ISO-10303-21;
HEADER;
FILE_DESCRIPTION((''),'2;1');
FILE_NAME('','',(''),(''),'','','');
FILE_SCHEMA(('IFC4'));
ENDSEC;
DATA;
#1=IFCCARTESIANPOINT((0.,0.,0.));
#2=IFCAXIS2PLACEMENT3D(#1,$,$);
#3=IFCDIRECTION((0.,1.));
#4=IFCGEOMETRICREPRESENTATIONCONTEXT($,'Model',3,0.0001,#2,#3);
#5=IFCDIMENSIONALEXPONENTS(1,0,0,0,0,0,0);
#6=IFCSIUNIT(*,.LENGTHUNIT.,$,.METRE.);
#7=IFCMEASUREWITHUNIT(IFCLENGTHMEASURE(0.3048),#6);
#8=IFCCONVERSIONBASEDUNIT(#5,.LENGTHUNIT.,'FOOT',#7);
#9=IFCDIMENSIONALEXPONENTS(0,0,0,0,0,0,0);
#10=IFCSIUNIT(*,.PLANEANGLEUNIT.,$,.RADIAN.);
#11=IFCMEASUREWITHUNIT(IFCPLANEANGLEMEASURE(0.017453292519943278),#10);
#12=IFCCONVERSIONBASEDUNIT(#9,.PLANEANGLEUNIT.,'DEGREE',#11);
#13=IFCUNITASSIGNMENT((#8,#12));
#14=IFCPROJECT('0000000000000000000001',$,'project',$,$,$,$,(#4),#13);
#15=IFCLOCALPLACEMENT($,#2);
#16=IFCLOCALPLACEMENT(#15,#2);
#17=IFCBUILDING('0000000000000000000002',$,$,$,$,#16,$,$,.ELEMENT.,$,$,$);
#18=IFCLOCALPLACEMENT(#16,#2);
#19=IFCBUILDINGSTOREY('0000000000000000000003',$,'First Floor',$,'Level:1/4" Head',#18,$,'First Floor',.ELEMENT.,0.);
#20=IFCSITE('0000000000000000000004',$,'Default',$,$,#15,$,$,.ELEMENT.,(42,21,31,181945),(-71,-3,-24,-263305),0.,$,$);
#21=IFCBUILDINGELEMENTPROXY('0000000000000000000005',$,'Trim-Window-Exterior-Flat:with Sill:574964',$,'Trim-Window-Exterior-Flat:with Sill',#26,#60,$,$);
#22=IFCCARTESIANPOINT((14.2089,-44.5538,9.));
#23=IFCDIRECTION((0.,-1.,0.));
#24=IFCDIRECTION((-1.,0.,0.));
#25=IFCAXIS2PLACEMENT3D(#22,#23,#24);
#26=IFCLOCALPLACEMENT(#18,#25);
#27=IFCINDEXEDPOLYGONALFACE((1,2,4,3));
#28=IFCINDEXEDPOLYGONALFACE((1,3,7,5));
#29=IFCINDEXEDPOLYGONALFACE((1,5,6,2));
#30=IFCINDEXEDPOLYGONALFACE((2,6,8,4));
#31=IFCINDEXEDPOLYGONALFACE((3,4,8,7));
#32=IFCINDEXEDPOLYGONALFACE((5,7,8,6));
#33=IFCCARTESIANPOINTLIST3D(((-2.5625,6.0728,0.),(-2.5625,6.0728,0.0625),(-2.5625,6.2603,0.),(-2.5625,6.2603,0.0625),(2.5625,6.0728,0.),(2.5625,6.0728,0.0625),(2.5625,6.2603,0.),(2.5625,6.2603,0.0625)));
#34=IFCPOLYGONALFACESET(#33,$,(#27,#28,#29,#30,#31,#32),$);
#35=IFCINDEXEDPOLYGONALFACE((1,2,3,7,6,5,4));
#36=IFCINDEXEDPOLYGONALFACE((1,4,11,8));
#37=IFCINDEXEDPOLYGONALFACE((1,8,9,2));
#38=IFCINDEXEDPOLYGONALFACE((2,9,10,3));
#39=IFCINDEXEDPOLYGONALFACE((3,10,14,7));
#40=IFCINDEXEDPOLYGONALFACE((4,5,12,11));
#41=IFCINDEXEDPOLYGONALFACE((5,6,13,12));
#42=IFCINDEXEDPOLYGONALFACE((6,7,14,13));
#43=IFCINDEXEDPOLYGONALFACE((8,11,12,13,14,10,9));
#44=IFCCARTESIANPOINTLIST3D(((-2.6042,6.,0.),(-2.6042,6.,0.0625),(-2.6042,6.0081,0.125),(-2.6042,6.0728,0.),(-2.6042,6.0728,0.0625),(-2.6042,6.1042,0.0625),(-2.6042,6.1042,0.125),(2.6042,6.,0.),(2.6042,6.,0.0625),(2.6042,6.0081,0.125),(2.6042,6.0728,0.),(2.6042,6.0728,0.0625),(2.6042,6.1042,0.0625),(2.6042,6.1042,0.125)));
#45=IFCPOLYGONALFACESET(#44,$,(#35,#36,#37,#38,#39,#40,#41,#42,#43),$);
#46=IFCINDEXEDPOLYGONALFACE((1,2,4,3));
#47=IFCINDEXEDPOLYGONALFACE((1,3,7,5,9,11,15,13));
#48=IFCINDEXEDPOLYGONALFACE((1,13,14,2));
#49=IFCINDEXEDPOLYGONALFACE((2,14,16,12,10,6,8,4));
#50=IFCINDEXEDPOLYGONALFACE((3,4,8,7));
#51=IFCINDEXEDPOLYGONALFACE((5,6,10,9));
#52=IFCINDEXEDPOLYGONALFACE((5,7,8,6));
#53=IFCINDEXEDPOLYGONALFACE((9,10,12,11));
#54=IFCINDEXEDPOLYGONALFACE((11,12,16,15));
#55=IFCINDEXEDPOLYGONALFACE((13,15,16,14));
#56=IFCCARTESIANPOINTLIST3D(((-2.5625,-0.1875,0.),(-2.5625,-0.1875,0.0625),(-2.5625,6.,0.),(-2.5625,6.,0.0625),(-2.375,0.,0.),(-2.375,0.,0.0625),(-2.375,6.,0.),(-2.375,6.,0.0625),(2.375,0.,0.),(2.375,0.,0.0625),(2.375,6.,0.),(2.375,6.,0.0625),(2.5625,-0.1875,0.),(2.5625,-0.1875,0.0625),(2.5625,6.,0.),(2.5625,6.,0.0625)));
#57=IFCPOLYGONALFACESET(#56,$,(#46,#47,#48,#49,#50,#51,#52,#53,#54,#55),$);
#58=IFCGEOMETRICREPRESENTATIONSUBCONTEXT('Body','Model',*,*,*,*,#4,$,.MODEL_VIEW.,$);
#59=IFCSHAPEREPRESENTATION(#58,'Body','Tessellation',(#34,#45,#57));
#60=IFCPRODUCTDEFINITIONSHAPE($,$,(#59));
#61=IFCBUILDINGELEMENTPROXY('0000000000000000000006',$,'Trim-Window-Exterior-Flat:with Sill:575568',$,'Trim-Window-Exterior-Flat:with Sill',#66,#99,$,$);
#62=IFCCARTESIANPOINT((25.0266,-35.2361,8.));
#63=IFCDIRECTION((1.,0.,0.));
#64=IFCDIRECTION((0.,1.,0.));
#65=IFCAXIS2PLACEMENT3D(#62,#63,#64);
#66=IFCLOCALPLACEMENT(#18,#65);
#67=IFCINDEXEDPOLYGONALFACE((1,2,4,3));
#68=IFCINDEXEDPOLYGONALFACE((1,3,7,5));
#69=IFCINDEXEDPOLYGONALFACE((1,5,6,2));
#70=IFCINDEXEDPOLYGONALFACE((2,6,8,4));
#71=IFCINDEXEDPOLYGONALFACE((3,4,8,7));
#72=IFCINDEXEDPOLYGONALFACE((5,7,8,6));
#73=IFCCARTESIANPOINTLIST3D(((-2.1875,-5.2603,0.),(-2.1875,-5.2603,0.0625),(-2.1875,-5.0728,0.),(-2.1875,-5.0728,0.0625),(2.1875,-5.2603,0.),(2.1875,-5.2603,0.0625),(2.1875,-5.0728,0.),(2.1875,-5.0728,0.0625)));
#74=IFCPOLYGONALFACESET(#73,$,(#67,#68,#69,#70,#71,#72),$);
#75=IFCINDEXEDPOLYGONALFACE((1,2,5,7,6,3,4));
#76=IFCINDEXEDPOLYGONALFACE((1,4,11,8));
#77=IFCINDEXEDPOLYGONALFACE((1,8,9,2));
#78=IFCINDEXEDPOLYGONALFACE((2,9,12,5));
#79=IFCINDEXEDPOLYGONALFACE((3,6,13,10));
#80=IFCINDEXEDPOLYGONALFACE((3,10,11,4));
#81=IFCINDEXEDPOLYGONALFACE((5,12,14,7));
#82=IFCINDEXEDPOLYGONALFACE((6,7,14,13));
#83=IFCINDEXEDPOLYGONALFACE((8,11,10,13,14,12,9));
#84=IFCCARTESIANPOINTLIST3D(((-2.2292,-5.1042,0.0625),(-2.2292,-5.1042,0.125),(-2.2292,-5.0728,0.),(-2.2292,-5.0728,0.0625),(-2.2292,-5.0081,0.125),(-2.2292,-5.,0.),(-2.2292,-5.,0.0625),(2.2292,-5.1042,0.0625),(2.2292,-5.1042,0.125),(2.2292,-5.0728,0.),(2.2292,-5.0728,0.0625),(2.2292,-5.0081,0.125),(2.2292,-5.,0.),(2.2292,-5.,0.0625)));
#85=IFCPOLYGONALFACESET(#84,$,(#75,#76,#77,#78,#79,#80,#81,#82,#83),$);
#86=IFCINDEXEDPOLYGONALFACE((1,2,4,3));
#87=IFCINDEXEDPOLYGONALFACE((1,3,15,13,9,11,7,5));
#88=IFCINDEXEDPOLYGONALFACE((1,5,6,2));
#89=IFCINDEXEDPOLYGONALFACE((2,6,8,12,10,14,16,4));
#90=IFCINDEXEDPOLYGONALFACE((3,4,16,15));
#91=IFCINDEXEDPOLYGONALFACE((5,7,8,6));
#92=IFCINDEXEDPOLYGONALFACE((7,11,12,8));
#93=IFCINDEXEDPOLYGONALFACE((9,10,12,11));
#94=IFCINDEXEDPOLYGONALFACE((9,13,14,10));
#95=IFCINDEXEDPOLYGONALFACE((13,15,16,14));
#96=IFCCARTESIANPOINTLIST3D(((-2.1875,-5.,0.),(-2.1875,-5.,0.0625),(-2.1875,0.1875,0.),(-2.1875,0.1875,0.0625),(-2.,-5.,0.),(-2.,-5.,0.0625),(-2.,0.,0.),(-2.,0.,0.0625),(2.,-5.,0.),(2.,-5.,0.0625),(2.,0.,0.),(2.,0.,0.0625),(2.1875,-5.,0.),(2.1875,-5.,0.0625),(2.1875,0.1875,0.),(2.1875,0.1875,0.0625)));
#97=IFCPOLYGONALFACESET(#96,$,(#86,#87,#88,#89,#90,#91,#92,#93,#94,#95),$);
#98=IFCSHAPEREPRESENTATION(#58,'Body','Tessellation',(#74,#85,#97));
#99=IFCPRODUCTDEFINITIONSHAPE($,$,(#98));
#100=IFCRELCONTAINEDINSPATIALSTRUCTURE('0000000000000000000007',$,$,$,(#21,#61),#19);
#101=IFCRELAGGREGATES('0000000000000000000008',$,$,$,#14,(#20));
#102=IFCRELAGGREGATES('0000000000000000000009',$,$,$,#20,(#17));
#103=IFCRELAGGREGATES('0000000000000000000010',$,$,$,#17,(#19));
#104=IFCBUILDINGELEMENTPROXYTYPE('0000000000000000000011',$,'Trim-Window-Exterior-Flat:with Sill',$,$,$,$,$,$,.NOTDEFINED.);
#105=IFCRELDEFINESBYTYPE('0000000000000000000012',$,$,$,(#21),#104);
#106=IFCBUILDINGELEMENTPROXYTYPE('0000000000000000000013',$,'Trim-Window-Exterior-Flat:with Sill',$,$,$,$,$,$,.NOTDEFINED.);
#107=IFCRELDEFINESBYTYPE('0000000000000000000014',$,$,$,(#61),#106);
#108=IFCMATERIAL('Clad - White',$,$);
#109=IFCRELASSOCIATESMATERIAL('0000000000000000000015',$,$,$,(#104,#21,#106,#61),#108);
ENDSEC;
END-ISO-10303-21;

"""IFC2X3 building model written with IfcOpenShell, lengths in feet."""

from ifc_helpers import new_model, entity, si_unit, converted_unit, direction, frame, frame_2d, origin, place, context, subcontext, project, spatial, polyline, rectangle, outline, extrude, source, transform, mapped, material, type_object, type_shapes, element, save


model = new_model("IFC2X3")

# Units and contexts
model_context = context("Model", 3, precision=0.0001, world=origin(), true_north=direction((0.0, 1.0)))
body_context = subcontext(model_context, "Body", "Model", "MODEL_VIEW")
ifc_project = project(units=[converted_unit("LENGTHUNIT", "FOOT", entity("IfcLengthMeasure", 0.3048), si_unit("LENGTHUNIT", "METRE"), dimensions=[1, 0, 0, 0, 0, 0, 0]), converted_unit("PLANEANGLEUNIT", "DEGREE", entity("IfcPlaneAngleMeasure", 0.017453292519943278), si_unit("PLANEANGLEUNIT", "RADIAN"), dimensions=[0, 0, 0, 0, 0, 0, 0])], contexts=[model_context])

# Site, building, storey
site_placement = place(None, origin())
site = spatial("IfcSite", under=ifc_project, at=site_placement, Name="Default", CompositionType="ELEMENT", RefLatitude=(42, 21, 31, 181945), RefLongitude=(-71, -3, -24, -263305), RefElevation=0.0)
building_placement = place(site_placement, origin())
building = spatial("IfcBuilding", under=site, at=building_placement, CompositionType="ELEMENT")
storey_placement = place(building_placement, origin())
storey = spatial("IfcBuildingStorey", under=building, at=storey_placement, Name="First Floor", ObjectType="Level:1/4\" Head", LongName="First Floor", CompositionType="ELEMENT", Elevation=0.0)

# Building element proxies
ifc_material_1 = material(Name="Clad - White")
building_element_proxy_type_1 = type_object("IfcBuildingElementProxyType", Name="Trim-Window-Exterior-Flat:with Sill", PredefinedType="NOTDEFINED", material=ifc_material_1)
shared_shape_1 = source(origin(), body_context, "Body", "SweptSolid", [
    extrude(rectangle(XDim=0.1875, YDim=5.125, at=frame_2d((0.0, 0.0), x_axis=(1.0, 0.0))), frame((0.0, 6.1665, 0.0), z_axis=(0.0, 0.0, 1.0), x_axis=(0.0, 1.0, 0.0)), (0.0, 0.0, 1.0), 0.0625),
    extrude(outline(polyline([(-0.0525, -0.0625), (0.0436, -0.0625), (0.0517, 0.0), (0.0517, 0.0625), (-0.0211, 0.0625), (-0.0211, 0.0), (-0.0525, 0.0), (-0.0525, -0.0625)])), frame((-2.6042, 6.0517, 0.0625), z_axis=(1.0, 0.0, 0.0), x_axis=(0.0, -1.0, 0.0)), (0.0, 0.0, 1.0), 5.2083),
    extrude(outline(polyline([(-2.5625, -3.1406), (2.5625, -3.1406), (2.5625, 3.0469), (2.375, 3.0469), (2.375, -2.9531), (-2.375, -2.9531), (-2.375, 3.0469), (-2.5625, 3.0469), (-2.5625, -3.1406)])), frame((0.0, 2.9531, 0.0)), (0.0, 0.0, 1.0), 0.0625),
])
type_shapes(building_element_proxy_type_1, [shared_shape_1])
proxy_1_placement = place(storey_placement, frame((14.2089, -44.5538, 9.0), z_axis=(0.0, -1.0, 0.0), x_axis=(-1.0, 0.0, 0.0)))
element("IfcBuildingElementProxy", 1, at=proxy_1_placement, inside=storey, type_object=building_element_proxy_type_1, material=ifc_material_1, Name="Trim-Window-Exterior-Flat:with Sill:574964", ObjectType="Trim-Window-Exterior-Flat:with Sill", context=body_context, shape_type="MappedRepresentation", body=[
    mapped(shared_shape_1, transform((0.0, 0.0, 0.0), scale=1.0)),
])
building_element_proxy_type_2 = type_object("IfcBuildingElementProxyType", Name="Trim-Window-Exterior-Flat:with Sill", PredefinedType="NOTDEFINED", material=ifc_material_1)
shared_shape_2 = source(origin(), body_context, "Body", "SweptSolid", [
    extrude(rectangle(XDim=4.375, YDim=0.1875, at=frame_2d((0.0, 0.0), x_axis=(1.0, 0.0))), frame((0.0, -5.1665, 0.0), z_axis=(0.0, 0.0, 1.0), x_axis=(-1.0, 0.0, 0.0)), (0.0, 0.0, 1.0), 0.0625),
    extrude(outline(polyline([(-0.0625, -0.0525), (0.0, -0.0525), (0.0, -0.0211), (0.0625, -0.0211), (0.0625, 0.0517), (0.0, 0.0517), (-0.0625, 0.0436), (-0.0625, -0.0525)])), frame((-2.2292, -5.0517, 0.0625), z_axis=(1.0, 0.0, 0.0), x_axis=(0.0, 0.0, -1.0)), (0.0, 0.0, 1.0), 4.4583),
    extrude(outline(polyline([(-2.6406, -2.1875), (2.5469, -2.1875), (2.5469, -2.0), (-2.4531, -2.0), (-2.4531, 2.0), (2.5469, 2.0), (2.5469, 2.1875), (-2.6406, 2.1875), (-2.6406, -2.1875)])), frame((0.0, -2.4531, 0.0), z_axis=(0.0, 0.0, 1.0), x_axis=(0.0, -1.0, 0.0)), (0.0, 0.0, 1.0), 0.0625),
])
type_shapes(building_element_proxy_type_2, [shared_shape_2])
proxy_2_placement = place(storey_placement, frame((25.0266, -35.2361, 8.0), z_axis=(1.0, 0.0, 0.0), x_axis=(0.0, 1.0, 0.0)))
element("IfcBuildingElementProxy", 2, at=proxy_2_placement, inside=storey, type_object=building_element_proxy_type_2, material=ifc_material_1, Name="Trim-Window-Exterior-Flat:with Sill:575568", ObjectType="Trim-Window-Exterior-Flat:with Sill", context=body_context, shape_type="MappedRepresentation", body=[
    mapped(shared_shape_2, transform((0.0, 0.0, 0.0), scale=1.0)),
])

save(model, "model.ifc")
